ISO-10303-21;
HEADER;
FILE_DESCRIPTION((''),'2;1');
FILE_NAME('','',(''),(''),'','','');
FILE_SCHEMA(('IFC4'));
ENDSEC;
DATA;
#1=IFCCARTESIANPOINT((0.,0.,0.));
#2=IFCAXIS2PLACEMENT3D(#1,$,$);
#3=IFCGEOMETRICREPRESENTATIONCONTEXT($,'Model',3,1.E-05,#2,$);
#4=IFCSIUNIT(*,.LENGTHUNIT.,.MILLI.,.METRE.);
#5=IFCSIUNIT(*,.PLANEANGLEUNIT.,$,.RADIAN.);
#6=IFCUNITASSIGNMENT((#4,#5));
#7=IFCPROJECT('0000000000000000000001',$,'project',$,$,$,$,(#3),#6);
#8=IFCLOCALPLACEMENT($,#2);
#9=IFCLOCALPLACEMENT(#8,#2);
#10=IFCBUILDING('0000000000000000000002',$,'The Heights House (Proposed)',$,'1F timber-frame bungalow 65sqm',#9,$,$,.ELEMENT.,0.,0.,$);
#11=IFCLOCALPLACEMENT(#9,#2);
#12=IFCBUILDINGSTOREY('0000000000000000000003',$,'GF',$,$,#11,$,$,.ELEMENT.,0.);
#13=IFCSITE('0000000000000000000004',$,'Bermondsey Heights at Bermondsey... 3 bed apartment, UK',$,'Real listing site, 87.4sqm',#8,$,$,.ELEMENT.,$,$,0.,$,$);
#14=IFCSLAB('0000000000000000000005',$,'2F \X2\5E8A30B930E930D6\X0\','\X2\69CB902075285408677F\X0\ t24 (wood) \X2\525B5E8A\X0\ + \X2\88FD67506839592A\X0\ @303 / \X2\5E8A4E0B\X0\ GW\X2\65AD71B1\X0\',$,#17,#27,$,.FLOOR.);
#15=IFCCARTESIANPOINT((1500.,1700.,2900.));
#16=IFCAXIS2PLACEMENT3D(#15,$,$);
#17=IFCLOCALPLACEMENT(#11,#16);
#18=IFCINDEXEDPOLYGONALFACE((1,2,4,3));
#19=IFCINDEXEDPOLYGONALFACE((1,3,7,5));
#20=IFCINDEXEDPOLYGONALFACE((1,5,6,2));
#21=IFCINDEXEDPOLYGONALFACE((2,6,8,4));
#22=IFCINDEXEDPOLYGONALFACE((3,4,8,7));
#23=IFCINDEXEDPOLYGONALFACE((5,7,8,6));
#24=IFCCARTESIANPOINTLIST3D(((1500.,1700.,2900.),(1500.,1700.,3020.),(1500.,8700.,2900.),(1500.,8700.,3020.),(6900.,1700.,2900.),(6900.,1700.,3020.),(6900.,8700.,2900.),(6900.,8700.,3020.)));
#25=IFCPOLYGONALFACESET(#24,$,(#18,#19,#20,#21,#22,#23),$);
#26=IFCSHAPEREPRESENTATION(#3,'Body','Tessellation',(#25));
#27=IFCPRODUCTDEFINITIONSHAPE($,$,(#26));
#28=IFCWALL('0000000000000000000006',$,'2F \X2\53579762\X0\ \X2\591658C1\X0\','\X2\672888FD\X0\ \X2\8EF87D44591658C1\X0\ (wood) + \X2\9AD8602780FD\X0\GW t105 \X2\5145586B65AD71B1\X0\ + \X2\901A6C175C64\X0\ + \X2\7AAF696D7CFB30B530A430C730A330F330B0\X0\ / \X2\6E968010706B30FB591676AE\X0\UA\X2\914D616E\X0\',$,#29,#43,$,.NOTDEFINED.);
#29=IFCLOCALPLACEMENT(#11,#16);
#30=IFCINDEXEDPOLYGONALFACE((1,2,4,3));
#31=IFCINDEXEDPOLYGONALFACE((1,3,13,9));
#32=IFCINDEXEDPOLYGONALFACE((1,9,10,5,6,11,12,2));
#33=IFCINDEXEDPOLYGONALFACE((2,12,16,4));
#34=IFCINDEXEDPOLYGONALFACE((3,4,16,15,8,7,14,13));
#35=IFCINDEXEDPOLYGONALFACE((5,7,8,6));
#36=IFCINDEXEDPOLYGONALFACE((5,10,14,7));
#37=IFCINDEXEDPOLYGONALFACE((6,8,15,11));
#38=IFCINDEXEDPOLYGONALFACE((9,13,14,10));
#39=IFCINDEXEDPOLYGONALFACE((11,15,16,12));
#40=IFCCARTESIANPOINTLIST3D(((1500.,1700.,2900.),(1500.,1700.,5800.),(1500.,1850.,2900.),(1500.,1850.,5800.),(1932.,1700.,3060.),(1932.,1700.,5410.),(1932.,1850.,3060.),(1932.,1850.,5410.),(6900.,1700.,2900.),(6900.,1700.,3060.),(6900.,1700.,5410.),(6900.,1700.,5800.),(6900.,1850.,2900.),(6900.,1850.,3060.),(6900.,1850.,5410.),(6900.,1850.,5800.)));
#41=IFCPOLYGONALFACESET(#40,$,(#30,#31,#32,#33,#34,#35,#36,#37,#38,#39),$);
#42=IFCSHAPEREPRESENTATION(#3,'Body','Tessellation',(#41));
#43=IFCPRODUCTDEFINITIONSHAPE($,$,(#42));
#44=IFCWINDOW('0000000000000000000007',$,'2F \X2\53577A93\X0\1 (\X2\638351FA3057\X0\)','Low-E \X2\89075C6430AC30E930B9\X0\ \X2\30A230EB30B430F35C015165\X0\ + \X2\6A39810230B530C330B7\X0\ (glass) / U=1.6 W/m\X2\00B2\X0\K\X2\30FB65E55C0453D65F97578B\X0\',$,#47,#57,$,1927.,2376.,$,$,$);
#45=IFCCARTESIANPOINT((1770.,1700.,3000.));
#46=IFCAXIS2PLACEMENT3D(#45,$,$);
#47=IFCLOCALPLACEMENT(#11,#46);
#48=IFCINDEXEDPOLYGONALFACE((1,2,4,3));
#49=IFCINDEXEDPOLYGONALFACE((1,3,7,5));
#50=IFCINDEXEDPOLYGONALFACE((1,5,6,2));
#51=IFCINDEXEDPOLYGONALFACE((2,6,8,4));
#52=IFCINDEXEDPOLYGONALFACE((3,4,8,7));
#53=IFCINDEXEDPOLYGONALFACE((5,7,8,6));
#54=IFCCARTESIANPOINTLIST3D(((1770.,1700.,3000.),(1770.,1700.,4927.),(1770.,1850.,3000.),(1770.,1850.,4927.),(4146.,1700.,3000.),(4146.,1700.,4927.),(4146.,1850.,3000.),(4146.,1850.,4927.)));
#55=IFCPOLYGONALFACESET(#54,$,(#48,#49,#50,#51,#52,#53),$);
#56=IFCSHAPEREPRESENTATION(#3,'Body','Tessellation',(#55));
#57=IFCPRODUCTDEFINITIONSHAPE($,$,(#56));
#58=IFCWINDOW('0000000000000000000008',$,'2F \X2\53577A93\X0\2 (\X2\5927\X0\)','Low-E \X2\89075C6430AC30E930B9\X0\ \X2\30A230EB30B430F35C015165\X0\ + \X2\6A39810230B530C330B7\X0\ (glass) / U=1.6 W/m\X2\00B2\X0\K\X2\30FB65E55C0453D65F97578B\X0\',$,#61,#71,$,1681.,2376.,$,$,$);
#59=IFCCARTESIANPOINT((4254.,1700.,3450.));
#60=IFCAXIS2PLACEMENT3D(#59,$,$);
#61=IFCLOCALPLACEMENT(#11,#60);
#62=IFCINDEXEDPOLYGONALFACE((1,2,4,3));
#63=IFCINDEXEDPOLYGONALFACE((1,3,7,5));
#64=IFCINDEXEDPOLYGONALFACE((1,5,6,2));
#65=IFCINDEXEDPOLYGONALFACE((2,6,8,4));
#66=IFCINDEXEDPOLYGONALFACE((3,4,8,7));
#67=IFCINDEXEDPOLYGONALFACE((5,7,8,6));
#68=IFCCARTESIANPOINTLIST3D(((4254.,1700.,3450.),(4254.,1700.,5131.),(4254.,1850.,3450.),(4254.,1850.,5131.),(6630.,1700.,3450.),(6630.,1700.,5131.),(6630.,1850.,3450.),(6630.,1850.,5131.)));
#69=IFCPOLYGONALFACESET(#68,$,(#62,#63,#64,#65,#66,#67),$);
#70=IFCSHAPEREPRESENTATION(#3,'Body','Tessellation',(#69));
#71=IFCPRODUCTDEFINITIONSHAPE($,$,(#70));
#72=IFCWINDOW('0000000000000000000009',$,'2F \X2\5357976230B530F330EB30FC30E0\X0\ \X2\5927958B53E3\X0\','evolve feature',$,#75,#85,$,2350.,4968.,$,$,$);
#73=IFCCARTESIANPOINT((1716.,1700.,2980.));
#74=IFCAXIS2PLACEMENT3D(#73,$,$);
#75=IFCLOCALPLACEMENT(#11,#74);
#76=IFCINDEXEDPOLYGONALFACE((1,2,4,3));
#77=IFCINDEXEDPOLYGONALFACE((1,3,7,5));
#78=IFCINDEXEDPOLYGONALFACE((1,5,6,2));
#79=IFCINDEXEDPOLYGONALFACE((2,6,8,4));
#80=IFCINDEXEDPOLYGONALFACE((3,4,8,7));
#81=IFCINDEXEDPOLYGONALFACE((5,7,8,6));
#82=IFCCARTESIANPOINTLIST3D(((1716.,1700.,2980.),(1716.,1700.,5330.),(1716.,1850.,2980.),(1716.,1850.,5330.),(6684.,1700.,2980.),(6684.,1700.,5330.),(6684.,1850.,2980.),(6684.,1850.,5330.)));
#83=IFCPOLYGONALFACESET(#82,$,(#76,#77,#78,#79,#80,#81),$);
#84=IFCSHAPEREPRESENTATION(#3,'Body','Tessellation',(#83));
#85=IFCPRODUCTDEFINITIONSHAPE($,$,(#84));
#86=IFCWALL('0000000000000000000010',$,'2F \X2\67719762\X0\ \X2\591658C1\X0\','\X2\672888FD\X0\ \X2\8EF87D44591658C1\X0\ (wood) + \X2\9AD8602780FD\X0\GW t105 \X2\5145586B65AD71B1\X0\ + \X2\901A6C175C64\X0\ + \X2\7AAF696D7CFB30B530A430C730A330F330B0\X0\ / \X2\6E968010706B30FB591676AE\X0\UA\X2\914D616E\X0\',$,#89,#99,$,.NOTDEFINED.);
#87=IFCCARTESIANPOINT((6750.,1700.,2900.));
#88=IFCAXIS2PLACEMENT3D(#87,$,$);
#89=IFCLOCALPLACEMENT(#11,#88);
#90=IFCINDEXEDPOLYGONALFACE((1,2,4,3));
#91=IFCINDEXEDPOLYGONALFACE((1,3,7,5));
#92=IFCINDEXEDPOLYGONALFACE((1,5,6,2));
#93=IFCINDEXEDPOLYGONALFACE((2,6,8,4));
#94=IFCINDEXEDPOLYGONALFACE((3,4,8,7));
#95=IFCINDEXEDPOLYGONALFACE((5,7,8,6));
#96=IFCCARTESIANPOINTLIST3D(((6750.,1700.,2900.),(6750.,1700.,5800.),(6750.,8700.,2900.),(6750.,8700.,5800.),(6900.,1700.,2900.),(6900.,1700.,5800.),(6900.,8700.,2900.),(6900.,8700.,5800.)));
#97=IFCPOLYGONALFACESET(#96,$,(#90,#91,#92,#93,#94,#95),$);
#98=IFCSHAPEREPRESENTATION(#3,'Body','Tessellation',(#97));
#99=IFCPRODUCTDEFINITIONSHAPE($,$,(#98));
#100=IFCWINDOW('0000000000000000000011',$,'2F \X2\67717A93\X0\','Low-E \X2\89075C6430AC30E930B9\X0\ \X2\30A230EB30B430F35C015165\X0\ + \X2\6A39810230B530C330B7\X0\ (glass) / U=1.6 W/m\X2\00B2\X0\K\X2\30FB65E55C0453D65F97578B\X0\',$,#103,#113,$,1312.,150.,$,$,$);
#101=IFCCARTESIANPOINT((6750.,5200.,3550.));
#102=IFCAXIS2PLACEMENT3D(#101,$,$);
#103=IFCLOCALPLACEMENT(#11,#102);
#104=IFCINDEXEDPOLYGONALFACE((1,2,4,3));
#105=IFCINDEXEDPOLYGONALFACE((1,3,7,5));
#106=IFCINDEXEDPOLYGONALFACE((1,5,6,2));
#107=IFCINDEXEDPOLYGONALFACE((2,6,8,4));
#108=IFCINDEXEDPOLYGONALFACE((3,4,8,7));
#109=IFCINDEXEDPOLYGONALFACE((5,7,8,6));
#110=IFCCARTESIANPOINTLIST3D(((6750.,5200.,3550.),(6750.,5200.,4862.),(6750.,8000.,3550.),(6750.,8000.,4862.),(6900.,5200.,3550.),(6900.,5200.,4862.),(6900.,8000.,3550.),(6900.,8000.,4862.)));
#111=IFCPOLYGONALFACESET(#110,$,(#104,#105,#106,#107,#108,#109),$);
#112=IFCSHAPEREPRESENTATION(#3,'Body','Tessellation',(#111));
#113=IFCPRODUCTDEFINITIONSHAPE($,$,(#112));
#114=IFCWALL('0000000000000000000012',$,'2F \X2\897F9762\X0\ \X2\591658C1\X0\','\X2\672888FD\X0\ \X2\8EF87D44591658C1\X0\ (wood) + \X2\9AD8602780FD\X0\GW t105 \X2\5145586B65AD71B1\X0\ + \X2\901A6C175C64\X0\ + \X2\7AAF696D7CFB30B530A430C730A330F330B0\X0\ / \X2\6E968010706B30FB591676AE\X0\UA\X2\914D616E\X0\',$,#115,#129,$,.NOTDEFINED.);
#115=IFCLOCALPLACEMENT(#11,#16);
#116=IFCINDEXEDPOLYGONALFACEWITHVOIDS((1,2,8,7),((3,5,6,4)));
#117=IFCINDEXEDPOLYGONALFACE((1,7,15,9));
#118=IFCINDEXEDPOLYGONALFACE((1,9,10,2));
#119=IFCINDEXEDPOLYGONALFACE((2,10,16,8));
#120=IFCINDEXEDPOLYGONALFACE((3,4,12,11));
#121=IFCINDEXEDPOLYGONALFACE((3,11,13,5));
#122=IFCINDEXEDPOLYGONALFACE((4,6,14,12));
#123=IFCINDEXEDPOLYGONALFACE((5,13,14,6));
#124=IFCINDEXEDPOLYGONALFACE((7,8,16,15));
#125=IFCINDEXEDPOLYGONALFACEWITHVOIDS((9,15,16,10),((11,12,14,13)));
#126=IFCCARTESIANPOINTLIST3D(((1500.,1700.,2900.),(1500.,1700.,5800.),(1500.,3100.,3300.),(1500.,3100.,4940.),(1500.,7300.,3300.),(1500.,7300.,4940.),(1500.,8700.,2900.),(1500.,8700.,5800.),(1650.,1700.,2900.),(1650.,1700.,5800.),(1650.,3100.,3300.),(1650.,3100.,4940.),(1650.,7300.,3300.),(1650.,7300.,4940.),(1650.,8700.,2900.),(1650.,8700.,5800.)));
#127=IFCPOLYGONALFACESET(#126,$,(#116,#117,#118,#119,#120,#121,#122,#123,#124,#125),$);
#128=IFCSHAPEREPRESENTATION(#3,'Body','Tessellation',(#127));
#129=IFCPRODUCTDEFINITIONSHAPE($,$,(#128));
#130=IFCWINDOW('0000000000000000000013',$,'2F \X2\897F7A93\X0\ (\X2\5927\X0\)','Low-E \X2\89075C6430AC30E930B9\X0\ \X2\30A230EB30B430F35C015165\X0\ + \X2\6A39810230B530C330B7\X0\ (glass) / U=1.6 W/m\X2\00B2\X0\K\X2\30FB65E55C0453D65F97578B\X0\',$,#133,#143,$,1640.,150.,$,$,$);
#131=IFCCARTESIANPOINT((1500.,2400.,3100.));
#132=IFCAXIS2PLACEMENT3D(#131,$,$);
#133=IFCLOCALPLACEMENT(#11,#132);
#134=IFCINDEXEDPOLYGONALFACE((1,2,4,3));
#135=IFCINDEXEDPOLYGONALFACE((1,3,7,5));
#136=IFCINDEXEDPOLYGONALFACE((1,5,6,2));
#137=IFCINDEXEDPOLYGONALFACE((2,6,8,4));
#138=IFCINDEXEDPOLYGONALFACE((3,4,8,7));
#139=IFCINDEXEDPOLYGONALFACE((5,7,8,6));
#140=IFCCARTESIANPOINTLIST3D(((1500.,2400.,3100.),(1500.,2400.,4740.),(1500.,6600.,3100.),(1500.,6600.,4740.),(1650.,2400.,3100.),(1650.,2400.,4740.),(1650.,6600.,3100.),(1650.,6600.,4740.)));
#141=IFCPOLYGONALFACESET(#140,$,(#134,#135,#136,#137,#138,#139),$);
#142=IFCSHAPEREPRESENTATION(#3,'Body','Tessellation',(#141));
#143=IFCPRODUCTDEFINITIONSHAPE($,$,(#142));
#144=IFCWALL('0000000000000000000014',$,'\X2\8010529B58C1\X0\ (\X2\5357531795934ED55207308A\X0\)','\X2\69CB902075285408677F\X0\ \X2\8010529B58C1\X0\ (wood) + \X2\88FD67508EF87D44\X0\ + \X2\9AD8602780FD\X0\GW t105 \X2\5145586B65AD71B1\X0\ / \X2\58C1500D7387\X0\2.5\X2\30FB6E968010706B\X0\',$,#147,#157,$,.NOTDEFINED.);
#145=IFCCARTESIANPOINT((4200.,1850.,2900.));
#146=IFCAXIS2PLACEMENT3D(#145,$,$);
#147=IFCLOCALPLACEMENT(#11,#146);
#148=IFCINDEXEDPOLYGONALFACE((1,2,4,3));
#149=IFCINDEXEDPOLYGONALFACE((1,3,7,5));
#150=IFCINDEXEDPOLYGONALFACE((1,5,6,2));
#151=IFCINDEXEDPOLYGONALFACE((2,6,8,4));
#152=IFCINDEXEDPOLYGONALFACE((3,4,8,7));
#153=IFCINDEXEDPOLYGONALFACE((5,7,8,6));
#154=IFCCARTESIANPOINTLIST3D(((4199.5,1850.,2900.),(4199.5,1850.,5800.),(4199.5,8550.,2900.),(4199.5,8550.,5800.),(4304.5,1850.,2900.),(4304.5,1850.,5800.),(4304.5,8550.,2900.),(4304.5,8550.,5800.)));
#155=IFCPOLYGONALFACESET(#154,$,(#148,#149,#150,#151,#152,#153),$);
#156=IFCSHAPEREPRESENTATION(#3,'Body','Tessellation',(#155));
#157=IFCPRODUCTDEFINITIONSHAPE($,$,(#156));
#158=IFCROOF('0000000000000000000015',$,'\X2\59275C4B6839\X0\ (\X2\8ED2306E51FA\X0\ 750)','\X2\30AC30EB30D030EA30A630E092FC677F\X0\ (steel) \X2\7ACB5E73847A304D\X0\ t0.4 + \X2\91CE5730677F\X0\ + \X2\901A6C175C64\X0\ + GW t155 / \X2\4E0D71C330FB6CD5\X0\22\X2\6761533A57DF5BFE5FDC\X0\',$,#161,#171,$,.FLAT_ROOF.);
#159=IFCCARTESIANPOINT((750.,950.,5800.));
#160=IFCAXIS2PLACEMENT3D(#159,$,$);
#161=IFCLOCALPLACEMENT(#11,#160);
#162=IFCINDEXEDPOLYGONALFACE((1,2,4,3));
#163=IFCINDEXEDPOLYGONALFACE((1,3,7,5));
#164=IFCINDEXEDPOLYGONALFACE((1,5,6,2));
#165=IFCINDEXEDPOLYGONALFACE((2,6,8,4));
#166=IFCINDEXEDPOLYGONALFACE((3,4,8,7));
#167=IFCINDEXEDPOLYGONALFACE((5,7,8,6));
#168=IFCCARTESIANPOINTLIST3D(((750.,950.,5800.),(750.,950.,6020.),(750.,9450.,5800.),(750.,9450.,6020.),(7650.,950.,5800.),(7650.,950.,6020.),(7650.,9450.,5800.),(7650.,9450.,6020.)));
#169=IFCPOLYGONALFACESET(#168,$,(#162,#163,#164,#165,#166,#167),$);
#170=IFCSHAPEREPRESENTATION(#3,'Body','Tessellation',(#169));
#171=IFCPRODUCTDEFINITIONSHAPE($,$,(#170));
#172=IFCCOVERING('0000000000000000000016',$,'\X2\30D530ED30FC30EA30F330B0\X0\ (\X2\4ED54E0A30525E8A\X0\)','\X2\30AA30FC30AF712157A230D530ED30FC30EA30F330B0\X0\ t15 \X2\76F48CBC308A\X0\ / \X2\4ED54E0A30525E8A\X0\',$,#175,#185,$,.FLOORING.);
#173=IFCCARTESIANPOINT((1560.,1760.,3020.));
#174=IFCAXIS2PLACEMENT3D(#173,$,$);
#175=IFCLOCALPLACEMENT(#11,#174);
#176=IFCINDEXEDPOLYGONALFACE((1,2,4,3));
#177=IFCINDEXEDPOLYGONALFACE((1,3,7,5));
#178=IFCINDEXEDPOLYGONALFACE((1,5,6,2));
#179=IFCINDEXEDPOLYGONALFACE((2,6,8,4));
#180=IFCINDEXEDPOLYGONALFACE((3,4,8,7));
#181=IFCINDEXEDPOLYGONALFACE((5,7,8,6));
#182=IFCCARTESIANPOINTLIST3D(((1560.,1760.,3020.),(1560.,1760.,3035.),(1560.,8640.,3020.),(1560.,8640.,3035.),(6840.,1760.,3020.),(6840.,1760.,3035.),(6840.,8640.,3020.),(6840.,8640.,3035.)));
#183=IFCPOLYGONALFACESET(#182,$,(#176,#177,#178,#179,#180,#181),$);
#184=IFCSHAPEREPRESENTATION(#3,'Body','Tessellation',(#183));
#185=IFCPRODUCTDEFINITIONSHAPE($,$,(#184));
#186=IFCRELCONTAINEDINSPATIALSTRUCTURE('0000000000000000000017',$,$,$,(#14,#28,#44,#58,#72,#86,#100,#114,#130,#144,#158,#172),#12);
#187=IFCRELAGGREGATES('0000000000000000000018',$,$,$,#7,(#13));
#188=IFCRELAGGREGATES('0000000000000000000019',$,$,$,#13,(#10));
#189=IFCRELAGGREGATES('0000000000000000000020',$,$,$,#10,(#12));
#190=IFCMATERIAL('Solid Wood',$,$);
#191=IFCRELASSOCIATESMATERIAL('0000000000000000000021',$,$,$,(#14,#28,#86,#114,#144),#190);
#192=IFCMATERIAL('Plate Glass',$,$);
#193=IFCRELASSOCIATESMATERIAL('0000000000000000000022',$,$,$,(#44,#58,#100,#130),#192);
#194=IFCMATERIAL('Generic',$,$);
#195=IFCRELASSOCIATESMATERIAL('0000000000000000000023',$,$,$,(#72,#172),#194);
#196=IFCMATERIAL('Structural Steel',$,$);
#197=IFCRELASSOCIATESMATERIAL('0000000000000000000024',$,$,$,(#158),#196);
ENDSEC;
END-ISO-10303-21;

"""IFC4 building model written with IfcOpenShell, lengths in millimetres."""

from ifc_helpers import new_model, si_unit, frame, frame_2d, origin, place, context, project, spatial, rectangle, extrude, material, element, fill, save


model = new_model("IFC4")

# Units and contexts
model_context = context("Model", 3, precision=1e-05, world=origin())
ifc_project = project(units=[si_unit("LENGTHUNIT", "METRE", prefix="MILLI"), si_unit("PLANEANGLEUNIT", "RADIAN")], contexts=[model_context])

# Site, building, storey
site_placement = place(None, origin())
site = spatial("IfcSite", under=ifc_project, at=site_placement, Name="Bermondsey Heights at Bermondsey... 3 bed apartment, UK", ObjectType="Real listing site, 87.4sqm", CompositionType="ELEMENT", RefElevation=0.0)
building_placement = place(site_placement, origin())
building = spatial("IfcBuilding", under=site, at=building_placement, Name="The Heights House (Proposed)", ObjectType="1F timber-frame bungalow 65sqm", CompositionType="ELEMENT", ElevationOfRefHeight=0.0, ElevationOfTerrain=0.0)
storey_placement = place(building_placement, origin())
storey = spatial("IfcBuildingStorey", under=building, at=storey_placement, Name="GF", CompositionType="ELEMENT", Elevation=0.0)

# Slab
ifc_material_1 = material(Name="Solid Wood")
slab_placement = place(storey_placement, frame((1500.0, 1700.0, 2900.0)))
element("IfcSlab", 1, at=slab_placement, inside=storey, material=ifc_material_1, Name="2F 床スラブ", Description="構造用合板 t24 (wood) 剛床 + 製材根太 @303 / 床下 GW断熱", PredefinedType="FLOOR", context=model_context, shape_type="SweptSolid", body=[
    extrude(rectangle(XDim=5400.0, YDim=7000.0, at=frame_2d((2700.0, 3500.0))), frame((1500.0, 1700.0, 2900.0)), (0.0, 0.0, 1.0), 120.0),
])

# Wall, openings, windows
wall_1_placement = place(storey_placement, frame((1500.0, 1700.0, 2900.0)))
wall_1 = element("IfcWall", 2, at=wall_1_placement, inside=storey, material=ifc_material_1, Name="2F 南面 外壁", Description="木製 軸組外壁 (wood) + 高性能GW t105 充填断熱 + 通気層 + 窯業系サイディング / 準耐火・外皮UA配慮", PredefinedType="NOTDEFINED", context=model_context, shape_type="SweptSolid", body=[
    extrude(rectangle(XDim=5400.0, YDim=150.0, at=frame_2d((2700.0, 75.0))), frame((1500.0, 1700.0, 2900.0)), (0.0, 0.0, 1.0), 2900.0),
])
opening_1_placement = place(storey_placement, frame((1770.0, 1700.0, 3000.0)))
opening_1 = element("IfcOpeningElement", 3, at=opening_1_placement, cuts=wall_1, PredefinedType="NOTDEFINED", context=model_context, shape_type="SweptSolid", body=[
    extrude(rectangle(XDim=2376.0, YDim=150.0, at=frame_2d((1188.0, 75.0))), frame((1770.0, 1700.0, 3000.0)), (0.0, 0.0, 1.0), 1927.0),
])
opening_2_placement = place(storey_placement, frame((4254.0, 1700.0, 3450.0)))
opening_2 = element("IfcOpeningElement", 4, at=opening_2_placement, cuts=wall_1, PredefinedType="NOTDEFINED", context=model_context, shape_type="SweptSolid", body=[
    extrude(rectangle(XDim=2376.0, YDim=150.0, at=frame_2d((1188.0, 75.0))), frame((4254.0, 1700.0, 3450.0)), (0.0, 0.0, 1.0), 1681.0),
])
opening_3_placement = place(storey_placement, frame((1716.0, 1700.0, 2980.0)))
opening_3 = element("IfcOpeningElement", 5, at=opening_3_placement, cuts=wall_1, PredefinedType="NOTDEFINED", context=model_context, shape_type="SweptSolid", body=[
    extrude(rectangle(XDim=4968.0, YDim=150.0, at=frame_2d((2484.0, 75.0))), frame((1716.0, 1700.0, 2980.0)), (0.0, 0.0, 1.0), 2350.0),
])
ifc_material_2 = material(Name="Plate Glass")
window_1_placement = place(storey_placement, frame((1770.0, 1700.0, 3000.0)))
window_1 = element("IfcWindow", 6, at=window_1_placement, inside=storey, material=ifc_material_2, Name="2F 南窓1 (掃出し)", Description="Low-E 複層ガラス アルゴン封入 + 樹脂サッシ (glass) / U=1.6 W/m²K・日射取得型", OverallHeight=1927.0, OverallWidth=2376.0, context=model_context, shape_type="SweptSolid", body=[
    extrude(rectangle(XDim=2376.0, YDim=150.0, at=frame_2d((1188.0, 75.0))), frame((1770.0, 1700.0, 3000.0)), (0.0, 0.0, 1.0), 1927.0),
])
fill(opening_1, window_1)
window_2_placement = place(storey_placement, frame((4254.0, 1700.0, 3450.0)))
window_2 = element("IfcWindow", 7, at=window_2_placement, inside=storey, material=ifc_material_2, Name="2F 南窓2 (大)", Description="Low-E 複層ガラス アルゴン封入 + 樹脂サッシ (glass) / U=1.6 W/m²K・日射取得型", OverallHeight=1681.0, OverallWidth=2376.0, context=model_context, shape_type="SweptSolid", body=[
    extrude(rectangle(XDim=2376.0, YDim=150.0, at=frame_2d((1188.0, 75.0))), frame((4254.0, 1700.0, 3450.0)), (0.0, 0.0, 1.0), 1681.0),
])
fill(opening_2, window_2)
ifc_material_3 = material(Name="Generic")
window_3_placement = place(storey_placement, frame((1716.0, 1700.0, 2980.0)))
window_3 = element("IfcWindow", 8, at=window_3_placement, inside=storey, material=ifc_material_3, Name="2F 南面サンルーム 大開口", Description="evolve feature", OverallHeight=2350.0, OverallWidth=4968.0, context=model_context, shape_type="SweptSolid", body=[
    extrude(rectangle(XDim=4968.0, YDim=150.0, at=frame_2d((2484.0, 75.0))), frame((1716.0, 1700.0, 2980.0)), (0.0, 0.0, 1.0), 2350.0),
])
fill(opening_3, window_3)

# Walls, openings, windows
wall_2_placement = place(storey_placement, frame((6750.0, 1700.0, 2900.0)))
wall_2 = element("IfcWall", 9, at=wall_2_placement, inside=storey, material=ifc_material_1, Name="2F 東面 外壁", Description="木製 軸組外壁 (wood) + 高性能GW t105 充填断熱 + 通気層 + 窯業系サイディング / 準耐火・外皮UA配慮", PredefinedType="NOTDEFINED", context=model_context, shape_type="SweptSolid", body=[
    extrude(rectangle(XDim=150.0, YDim=7000.0, at=frame_2d((75.0, 3500.0))), frame((6750.0, 1700.0, 2900.0)), (0.0, 0.0, 1.0), 2900.0),
])
opening_4_placement = place(storey_placement, frame((6750.0, 5200.0, 3550.0)))
opening_4 = element("IfcOpeningElement", 10, at=opening_4_placement, cuts=wall_2, PredefinedType="NOTDEFINED", context=model_context, shape_type="SweptSolid", body=[
    extrude(rectangle(XDim=150.0, YDim=2800.0, at=frame_2d((75.0, 1400.0))), frame((6750.0, 5200.0, 3550.0)), (0.0, 0.0, 1.0), 1312.0),
])
window_4_placement = place(storey_placement, frame((6750.0, 5200.0, 3550.0)))
window_4 = element("IfcWindow", 11, at=window_4_placement, inside=storey, material=ifc_material_2, Name="2F 東窓", Description="Low-E 複層ガラス アルゴン封入 + 樹脂サッシ (glass) / U=1.6 W/m²K・日射取得型", OverallHeight=1312.0, OverallWidth=150.0, context=model_context, shape_type="SweptSolid", body=[
    extrude(rectangle(XDim=150.0, YDim=2800.0, at=frame_2d((75.0, 1400.0))), frame((6750.0, 5200.0, 3550.0)), (0.0, 0.0, 1.0), 1312.0),
])
fill(opening_4, window_4)
wall_3_placement = place(storey_placement, frame((1500.0, 1700.0, 2900.0)))
wall_3 = element("IfcWall", 12, at=wall_3_placement, inside=storey, material=ifc_material_1, Name="2F 西面 外壁", Description="木製 軸組外壁 (wood) + 高性能GW t105 充填断熱 + 通気層 + 窯業系サイディング / 準耐火・外皮UA配慮", PredefinedType="NOTDEFINED", context=model_context, shape_type="SweptSolid", body=[
    extrude(rectangle(XDim=150.0, YDim=7000.0, at=frame_2d((75.0, 3500.0))), frame((1500.0, 1700.0, 2900.0)), (0.0, 0.0, 1.0), 2900.0),
])
opening_5_placement = place(storey_placement, frame((1500.0, 2400.0, 3100.0)))
opening_5 = element("IfcOpeningElement", 13, at=opening_5_placement, cuts=wall_3, PredefinedType="NOTDEFINED", context=model_context, shape_type="SweptSolid", body=[
    extrude(rectangle(XDim=150.0, YDim=4200.0, at=frame_2d((75.0, 2100.0))), frame((1500.0, 2400.0, 3100.0)), (0.0, 0.0, 1.0), 1640.0),
])
window_5_placement = place(storey_placement, frame((1500.0, 2400.0, 3100.0)))
window_5 = element("IfcWindow", 14, at=window_5_placement, inside=storey, material=ifc_material_2, Name="2F 西窓 (大)", Description="Low-E 複層ガラス アルゴン封入 + 樹脂サッシ (glass) / U=1.6 W/m²K・日射取得型", OverallHeight=1640.0, OverallWidth=150.0, context=model_context, shape_type="SweptSolid", body=[
    extrude(rectangle(XDim=150.0, YDim=4200.0, at=frame_2d((75.0, 2100.0))), frame((1500.0, 2400.0, 3100.0)), (0.0, 0.0, 1.0), 1640.0),
])
fill(opening_5, window_5)

# Wall
wall_4_placement = place(storey_placement, frame((4200.0, 1850.0, 2900.0)))
element("IfcWall", 15, at=wall_4_placement, inside=storey, material=ifc_material_1, Name="耐力壁 (南北間仕切り)", Description="構造用合板 耐力壁 (wood) + 製材軸組 + 高性能GW t105 充填断熱 / 壁倍率2.5・準耐火", PredefinedType="NOTDEFINED", context=model_context, shape_type="SweptSolid", body=[
    extrude(rectangle(XDim=105.0, YDim=6700.0, at=frame_2d((52.0, 3350.0))), frame((4200.0, 1850.0, 2900.0)), (0.0, 0.0, 1.0), 2900.0),
])

# Roof
ifc_material_4 = material(Name="Structural Steel")
roof_placement = place(storey_placement, frame((750.0, 950.0, 5800.0)))
element("IfcRoof", 16, at=roof_placement, inside=storey, material=ifc_material_4, Name="大屋根 (軒の出 750)", Description="ガルバリウム鋼板 (steel) 立平葺き t0.4 + 野地板 + 通気層 + GW t155 / 不燃・法22条区域対応", PredefinedType="FLAT_ROOF", context=model_context, shape_type="SweptSolid", body=[
    extrude(rectangle(XDim=6900.0, YDim=8500.0, at=frame_2d((3450.0, 4250.0))), frame((750.0, 950.0, 5800.0)), (0.0, 0.0, 1.0), 220.0),
])

# Covering
covering_placement = place(storey_placement, frame((1560.0, 1760.0, 3020.0)))
element("IfcCovering", 17, at=covering_placement, inside=storey, material=ifc_material_3, Name="フローリング (仕上げ床)", Description="オーク無垢フローリング t15 直貼り / 仕上げ床", PredefinedType="FLOORING", context=model_context, shape_type="SweptSolid", body=[
    extrude(rectangle(XDim=5280.0, YDim=6880.0, at=frame_2d((2640.0, 3440.0))), frame((1560.0, 1760.0, 3020.0)), (0.0, 0.0, 1.0), 15.0),
])

save(model, "model.ifc")
